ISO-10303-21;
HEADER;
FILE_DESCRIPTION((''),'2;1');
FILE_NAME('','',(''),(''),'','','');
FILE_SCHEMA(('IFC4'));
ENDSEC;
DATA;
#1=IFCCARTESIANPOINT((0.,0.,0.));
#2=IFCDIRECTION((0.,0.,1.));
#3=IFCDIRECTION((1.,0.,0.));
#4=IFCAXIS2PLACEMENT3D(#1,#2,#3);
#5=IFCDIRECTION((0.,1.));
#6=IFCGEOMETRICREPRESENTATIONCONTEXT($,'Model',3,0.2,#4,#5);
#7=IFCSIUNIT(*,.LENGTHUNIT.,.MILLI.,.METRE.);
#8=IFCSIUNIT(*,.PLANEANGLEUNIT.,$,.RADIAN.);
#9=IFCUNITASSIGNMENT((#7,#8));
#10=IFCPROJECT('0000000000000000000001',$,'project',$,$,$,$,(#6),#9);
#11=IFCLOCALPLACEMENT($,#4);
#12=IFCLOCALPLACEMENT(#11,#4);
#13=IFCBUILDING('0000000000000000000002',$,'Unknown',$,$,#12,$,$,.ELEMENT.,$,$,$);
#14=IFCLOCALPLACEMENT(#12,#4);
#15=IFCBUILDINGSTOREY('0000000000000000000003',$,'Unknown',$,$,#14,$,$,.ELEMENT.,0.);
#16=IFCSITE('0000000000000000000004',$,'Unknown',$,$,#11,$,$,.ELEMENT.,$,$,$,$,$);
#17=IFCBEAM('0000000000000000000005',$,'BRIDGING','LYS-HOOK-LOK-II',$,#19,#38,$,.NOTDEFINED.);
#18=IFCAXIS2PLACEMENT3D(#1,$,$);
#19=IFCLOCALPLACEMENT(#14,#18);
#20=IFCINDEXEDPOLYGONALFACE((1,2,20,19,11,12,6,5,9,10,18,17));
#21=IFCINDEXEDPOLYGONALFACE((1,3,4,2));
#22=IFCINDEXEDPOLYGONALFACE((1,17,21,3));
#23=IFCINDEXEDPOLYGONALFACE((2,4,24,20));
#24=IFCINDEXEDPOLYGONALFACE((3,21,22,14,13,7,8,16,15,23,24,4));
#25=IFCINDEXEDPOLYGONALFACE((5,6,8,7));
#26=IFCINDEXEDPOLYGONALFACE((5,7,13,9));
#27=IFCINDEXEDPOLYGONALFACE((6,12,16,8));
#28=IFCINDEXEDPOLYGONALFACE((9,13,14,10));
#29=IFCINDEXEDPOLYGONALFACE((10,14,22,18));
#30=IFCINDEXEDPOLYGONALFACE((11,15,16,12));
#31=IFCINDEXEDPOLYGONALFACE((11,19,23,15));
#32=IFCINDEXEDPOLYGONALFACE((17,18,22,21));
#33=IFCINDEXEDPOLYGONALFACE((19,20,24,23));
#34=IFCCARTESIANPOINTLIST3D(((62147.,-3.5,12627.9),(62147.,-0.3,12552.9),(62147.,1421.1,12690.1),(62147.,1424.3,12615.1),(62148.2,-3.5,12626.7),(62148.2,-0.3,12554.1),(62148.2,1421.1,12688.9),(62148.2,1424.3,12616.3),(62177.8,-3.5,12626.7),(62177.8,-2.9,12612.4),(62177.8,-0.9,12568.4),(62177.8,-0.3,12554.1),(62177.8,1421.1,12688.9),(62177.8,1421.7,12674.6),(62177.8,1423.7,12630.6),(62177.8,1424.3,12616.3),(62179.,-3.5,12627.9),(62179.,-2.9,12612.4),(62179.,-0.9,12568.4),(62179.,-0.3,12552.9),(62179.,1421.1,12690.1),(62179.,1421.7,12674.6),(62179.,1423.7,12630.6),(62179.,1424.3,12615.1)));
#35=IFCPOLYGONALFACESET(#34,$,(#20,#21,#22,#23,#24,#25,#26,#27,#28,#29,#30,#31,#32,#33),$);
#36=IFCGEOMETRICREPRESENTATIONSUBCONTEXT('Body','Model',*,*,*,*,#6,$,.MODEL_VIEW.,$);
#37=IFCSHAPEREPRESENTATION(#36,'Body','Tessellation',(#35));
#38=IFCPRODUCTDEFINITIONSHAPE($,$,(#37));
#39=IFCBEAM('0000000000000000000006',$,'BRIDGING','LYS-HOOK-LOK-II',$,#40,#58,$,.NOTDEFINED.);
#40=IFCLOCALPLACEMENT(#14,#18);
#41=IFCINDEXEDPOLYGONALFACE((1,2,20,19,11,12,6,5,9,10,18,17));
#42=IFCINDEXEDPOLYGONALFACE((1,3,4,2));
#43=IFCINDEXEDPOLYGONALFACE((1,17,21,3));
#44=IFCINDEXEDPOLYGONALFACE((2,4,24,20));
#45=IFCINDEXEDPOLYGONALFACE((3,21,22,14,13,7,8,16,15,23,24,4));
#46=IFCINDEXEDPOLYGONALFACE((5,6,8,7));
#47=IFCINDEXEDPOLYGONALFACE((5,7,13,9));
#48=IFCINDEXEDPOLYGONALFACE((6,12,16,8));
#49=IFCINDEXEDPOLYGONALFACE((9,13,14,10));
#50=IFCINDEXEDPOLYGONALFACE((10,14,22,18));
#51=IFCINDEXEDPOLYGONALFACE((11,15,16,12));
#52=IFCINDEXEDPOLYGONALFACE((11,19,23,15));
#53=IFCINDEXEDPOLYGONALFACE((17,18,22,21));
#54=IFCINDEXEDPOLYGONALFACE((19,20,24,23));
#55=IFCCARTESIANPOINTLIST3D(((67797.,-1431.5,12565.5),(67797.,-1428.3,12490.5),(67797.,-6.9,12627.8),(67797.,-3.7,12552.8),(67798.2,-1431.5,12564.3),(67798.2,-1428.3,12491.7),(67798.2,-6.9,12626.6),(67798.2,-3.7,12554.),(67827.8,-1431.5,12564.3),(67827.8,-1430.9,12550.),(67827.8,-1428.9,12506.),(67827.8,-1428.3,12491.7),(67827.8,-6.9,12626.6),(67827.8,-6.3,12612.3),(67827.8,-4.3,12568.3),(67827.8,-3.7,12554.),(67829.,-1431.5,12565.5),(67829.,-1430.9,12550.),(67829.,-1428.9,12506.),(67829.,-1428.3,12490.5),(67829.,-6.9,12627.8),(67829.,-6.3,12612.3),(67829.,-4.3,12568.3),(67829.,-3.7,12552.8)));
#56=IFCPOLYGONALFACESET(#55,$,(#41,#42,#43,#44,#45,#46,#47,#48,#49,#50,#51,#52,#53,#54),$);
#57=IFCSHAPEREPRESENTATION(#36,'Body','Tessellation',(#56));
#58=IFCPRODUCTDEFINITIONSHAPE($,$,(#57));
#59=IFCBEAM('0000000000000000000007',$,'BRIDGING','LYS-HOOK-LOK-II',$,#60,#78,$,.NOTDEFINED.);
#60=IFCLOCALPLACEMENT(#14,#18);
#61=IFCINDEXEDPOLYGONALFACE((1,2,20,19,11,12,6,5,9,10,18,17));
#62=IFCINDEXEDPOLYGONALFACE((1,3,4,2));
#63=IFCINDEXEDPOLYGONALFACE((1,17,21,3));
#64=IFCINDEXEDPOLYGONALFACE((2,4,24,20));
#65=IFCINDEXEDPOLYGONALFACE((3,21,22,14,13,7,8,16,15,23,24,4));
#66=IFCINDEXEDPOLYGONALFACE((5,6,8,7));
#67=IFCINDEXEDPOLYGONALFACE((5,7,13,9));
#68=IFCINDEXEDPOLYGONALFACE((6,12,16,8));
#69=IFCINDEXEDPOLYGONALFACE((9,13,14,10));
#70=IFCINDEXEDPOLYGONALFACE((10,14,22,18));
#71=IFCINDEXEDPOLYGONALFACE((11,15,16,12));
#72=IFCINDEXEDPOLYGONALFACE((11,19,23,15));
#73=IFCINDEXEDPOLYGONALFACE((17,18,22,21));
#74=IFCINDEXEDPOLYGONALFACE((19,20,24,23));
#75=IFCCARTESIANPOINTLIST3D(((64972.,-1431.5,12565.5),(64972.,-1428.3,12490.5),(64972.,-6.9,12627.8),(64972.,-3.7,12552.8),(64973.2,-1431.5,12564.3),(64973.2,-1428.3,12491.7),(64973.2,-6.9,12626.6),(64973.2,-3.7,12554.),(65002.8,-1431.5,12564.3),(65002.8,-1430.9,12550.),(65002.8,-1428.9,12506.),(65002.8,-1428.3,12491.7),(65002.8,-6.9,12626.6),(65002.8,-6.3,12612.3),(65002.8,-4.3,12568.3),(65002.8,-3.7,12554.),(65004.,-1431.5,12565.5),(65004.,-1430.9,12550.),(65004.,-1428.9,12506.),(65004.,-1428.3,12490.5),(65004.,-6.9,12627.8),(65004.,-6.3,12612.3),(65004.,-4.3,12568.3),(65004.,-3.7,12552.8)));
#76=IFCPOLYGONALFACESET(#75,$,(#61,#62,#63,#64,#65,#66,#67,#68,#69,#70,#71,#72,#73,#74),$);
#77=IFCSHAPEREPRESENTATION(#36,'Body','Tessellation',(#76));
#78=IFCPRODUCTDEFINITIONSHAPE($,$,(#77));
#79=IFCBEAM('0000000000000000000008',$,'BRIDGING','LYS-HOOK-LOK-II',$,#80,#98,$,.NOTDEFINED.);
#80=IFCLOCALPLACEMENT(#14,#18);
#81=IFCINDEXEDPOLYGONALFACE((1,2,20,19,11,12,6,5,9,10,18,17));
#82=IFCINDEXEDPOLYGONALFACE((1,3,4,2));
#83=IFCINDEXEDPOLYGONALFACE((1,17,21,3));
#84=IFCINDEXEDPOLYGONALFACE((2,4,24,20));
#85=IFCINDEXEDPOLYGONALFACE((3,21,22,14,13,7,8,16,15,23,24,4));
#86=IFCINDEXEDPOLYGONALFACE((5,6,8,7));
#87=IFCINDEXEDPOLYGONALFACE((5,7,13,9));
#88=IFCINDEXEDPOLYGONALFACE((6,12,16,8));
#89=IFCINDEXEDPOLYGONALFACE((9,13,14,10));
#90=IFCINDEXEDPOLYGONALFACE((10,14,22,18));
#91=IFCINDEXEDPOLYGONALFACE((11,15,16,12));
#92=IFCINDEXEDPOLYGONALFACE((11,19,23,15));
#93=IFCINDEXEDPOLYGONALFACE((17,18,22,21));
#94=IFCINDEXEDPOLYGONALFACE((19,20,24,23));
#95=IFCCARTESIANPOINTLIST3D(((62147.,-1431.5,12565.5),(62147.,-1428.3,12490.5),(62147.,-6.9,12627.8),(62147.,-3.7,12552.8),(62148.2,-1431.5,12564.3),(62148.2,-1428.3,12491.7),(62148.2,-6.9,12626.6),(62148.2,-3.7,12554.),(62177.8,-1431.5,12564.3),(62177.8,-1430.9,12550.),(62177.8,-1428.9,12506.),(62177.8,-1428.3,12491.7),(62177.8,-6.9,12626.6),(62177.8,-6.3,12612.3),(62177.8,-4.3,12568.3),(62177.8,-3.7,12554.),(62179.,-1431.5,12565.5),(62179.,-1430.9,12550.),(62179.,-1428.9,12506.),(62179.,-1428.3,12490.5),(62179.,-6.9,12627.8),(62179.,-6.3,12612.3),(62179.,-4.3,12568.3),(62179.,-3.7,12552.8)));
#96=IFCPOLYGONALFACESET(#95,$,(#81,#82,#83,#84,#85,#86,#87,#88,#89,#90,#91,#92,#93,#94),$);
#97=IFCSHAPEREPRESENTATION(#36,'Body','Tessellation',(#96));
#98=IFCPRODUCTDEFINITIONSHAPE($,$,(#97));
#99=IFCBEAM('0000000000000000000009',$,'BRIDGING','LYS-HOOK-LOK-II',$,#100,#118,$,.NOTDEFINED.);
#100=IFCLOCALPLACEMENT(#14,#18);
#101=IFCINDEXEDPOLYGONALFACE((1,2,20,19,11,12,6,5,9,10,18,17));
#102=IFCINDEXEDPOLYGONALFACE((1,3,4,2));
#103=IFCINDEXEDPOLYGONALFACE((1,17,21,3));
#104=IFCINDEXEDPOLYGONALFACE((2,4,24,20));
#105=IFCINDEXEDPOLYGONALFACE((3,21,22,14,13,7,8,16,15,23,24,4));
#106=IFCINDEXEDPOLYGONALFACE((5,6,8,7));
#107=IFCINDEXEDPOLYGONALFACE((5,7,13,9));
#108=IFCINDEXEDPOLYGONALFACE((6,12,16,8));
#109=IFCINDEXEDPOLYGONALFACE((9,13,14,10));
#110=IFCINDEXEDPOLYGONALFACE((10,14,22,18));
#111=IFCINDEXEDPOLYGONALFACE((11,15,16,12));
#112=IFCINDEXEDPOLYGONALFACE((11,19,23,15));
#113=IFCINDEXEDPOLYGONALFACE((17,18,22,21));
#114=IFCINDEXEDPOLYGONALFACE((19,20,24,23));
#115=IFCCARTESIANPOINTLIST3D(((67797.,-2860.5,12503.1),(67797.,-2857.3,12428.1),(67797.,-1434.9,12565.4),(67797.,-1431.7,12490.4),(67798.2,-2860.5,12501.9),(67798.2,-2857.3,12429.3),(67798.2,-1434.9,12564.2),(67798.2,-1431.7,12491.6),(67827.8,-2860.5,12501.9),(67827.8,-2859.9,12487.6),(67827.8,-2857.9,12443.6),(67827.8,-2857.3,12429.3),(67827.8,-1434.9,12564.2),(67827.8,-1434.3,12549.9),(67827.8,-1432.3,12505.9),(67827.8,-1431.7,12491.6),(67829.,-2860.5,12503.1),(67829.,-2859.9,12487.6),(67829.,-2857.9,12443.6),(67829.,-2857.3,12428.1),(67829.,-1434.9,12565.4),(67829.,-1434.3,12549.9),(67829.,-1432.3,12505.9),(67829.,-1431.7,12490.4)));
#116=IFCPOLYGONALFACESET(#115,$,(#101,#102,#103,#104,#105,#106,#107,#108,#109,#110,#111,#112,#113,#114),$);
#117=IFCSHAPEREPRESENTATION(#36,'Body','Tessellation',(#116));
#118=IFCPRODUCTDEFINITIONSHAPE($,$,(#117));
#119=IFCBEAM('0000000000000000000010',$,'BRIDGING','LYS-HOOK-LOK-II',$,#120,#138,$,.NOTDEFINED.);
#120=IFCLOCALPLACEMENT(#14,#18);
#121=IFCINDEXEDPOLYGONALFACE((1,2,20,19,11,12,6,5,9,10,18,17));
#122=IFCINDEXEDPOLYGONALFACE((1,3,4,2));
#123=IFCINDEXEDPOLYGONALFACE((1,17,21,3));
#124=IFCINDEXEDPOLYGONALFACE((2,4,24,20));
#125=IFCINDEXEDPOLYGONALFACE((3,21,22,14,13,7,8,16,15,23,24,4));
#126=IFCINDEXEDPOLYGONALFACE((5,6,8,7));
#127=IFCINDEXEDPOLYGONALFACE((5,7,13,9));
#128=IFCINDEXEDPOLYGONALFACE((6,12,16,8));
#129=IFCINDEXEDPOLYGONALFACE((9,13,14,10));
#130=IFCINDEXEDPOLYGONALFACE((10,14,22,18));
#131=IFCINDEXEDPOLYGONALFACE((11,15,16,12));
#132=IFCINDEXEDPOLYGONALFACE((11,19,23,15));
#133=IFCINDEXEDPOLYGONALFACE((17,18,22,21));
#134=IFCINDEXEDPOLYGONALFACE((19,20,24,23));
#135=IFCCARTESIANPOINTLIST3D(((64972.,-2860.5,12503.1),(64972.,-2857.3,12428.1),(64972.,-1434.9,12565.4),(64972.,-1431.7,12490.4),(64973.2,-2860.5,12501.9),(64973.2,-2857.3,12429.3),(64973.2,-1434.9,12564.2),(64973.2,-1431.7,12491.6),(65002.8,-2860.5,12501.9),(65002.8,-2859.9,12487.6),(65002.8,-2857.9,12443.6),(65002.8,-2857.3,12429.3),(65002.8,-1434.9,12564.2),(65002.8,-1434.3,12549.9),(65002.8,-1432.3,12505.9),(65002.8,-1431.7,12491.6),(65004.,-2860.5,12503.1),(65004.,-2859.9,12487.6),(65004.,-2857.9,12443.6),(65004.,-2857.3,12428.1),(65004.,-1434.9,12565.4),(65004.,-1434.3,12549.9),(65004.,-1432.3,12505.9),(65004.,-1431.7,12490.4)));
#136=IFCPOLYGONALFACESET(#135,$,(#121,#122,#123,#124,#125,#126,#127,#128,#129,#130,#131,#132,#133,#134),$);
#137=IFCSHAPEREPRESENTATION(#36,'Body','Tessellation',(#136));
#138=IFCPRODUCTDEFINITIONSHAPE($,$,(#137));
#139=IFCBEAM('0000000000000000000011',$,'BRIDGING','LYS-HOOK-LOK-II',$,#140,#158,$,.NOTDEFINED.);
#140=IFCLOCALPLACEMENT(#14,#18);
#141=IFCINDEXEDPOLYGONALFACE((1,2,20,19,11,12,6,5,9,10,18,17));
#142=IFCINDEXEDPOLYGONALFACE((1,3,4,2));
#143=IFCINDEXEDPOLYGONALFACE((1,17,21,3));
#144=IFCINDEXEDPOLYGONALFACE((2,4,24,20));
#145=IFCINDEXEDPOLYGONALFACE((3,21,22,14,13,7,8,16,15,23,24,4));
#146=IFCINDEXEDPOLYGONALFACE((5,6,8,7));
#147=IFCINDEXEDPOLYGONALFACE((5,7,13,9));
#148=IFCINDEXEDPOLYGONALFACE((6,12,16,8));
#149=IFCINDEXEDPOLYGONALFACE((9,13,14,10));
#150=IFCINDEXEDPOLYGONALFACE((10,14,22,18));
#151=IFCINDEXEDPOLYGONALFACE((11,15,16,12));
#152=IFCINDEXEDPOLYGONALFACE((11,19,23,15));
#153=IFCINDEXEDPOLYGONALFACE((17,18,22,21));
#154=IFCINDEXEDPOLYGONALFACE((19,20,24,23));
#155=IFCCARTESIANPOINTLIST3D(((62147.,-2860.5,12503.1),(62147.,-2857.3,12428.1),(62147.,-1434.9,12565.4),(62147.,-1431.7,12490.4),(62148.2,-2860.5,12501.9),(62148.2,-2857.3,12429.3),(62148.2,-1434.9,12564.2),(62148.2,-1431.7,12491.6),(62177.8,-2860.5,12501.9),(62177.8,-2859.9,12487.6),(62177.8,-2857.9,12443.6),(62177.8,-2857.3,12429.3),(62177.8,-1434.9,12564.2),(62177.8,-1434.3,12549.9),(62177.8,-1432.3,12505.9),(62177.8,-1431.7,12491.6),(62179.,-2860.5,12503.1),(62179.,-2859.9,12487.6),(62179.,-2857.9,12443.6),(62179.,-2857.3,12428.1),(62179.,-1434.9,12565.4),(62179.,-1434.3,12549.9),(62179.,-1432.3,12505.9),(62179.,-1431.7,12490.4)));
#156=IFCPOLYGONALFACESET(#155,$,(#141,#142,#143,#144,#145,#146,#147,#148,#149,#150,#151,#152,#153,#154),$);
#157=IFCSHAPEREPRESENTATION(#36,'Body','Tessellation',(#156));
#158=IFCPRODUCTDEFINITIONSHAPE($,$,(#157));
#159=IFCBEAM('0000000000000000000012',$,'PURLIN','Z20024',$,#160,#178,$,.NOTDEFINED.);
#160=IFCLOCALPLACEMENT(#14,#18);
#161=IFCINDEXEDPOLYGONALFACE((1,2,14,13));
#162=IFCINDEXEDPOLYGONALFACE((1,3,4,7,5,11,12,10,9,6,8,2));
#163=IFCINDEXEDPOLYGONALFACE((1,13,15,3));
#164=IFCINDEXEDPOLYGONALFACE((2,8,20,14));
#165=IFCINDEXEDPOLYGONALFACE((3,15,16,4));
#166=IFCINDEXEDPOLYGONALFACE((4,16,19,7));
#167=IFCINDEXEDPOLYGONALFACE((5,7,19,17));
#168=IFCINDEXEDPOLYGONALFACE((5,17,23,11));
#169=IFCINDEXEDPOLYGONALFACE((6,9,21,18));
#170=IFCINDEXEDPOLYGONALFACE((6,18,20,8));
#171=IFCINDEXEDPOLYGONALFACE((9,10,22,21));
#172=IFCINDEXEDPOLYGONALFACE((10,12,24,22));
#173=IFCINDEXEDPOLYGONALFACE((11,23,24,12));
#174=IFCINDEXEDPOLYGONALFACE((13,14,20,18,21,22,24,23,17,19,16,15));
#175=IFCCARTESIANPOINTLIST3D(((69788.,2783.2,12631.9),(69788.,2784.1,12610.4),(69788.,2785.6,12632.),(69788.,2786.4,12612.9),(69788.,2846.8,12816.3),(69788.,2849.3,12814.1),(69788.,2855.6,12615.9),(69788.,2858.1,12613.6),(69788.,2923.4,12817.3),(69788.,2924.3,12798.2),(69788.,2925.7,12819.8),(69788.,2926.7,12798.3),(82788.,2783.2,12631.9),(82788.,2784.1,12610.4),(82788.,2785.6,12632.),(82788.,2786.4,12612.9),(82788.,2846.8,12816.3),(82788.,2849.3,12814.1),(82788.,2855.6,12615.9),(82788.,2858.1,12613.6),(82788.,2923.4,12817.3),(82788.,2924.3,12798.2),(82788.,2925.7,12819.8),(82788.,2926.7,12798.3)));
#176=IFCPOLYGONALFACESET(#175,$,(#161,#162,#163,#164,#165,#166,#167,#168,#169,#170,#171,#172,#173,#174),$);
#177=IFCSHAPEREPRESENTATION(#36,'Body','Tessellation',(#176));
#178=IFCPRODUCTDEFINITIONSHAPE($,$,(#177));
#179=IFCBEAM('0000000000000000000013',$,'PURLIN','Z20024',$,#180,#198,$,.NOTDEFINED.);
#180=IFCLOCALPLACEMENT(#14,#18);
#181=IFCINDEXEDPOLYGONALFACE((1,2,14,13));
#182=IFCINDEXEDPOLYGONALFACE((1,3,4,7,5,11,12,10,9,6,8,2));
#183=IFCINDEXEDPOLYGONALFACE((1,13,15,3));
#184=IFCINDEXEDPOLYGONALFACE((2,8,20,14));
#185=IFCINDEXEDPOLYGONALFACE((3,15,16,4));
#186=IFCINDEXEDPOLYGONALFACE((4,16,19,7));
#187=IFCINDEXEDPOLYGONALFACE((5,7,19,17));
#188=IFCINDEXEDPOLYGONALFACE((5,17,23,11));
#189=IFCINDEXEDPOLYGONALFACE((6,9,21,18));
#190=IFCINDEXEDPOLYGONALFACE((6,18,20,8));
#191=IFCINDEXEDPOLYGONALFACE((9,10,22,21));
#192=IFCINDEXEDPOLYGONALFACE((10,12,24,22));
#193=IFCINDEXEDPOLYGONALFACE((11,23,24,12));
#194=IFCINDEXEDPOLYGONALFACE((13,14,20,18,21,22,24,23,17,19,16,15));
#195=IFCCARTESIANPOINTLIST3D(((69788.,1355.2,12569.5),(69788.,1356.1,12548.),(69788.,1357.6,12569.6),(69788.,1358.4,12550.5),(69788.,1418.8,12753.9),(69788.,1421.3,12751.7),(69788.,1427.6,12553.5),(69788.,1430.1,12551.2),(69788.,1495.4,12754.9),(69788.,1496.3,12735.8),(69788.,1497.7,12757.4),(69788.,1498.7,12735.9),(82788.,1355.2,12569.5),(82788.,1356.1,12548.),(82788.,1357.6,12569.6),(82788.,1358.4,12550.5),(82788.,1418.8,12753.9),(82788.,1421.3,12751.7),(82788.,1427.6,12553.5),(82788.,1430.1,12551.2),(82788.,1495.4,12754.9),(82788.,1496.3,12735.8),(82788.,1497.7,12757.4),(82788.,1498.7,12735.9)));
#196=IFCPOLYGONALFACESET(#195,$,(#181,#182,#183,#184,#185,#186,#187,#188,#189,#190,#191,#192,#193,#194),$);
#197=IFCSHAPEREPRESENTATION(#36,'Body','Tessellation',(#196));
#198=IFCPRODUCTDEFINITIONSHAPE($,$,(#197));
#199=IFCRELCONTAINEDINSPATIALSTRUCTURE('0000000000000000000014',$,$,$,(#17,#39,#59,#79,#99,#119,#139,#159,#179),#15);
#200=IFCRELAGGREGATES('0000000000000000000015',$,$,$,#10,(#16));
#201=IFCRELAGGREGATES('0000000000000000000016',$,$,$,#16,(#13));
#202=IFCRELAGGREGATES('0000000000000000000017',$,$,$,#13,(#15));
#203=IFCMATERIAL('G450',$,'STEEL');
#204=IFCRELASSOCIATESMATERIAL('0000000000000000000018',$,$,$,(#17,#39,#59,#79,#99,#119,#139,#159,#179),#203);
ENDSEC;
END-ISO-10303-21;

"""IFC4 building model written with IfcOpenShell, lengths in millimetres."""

from ifc_helpers import new_model, si_unit, direction, frame, origin_with_axes, place, context, subcontext, project, spatial, line, indexed_curve, outline, extrude, material, element, save


model = new_model("IFC4")

# Units and contexts
model_context = context("Model", 3, precision=0.2, world=origin_with_axes(), true_north=direction((0.0, 1.0)))
body_context = subcontext(model_context, "Body", "Model", "MODEL_VIEW")
ifc_project = project(units=[si_unit("LENGTHUNIT", "METRE", prefix="MILLI"), si_unit("PLANEANGLEUNIT", "RADIAN")], contexts=[model_context])

# Site, building, storey
site_placement = place(None, origin_with_axes())
site = spatial("IfcSite", under=ifc_project, at=site_placement, Name="Unknown", CompositionType="ELEMENT")
building_placement = place(site_placement, origin_with_axes())
building = spatial("IfcBuilding", under=site, at=building_placement, Name="Unknown", CompositionType="ELEMENT")
storey_placement = place(building_placement, origin_with_axes())
storey = spatial("IfcBuildingStorey", under=building, at=storey_placement, Name="Unknown", CompositionType="ELEMENT", Elevation=0.0)

# Beams
ifc_material_1 = material(Name="G450", Category="STEEL")
for number, where, z_axis, x_axis, name in (
    (1, (62163.0, -1.9, 12590.4), (1.0, 0.0, 0.0), (0.0, 0.999048, 0.04362), "BRIDGING"),
):
    element("IfcBeam", number, at=place(storey_placement, frame(where, z_axis=z_axis, x_axis=x_axis)), inside=storey, material=ifc_material_1, Name=name, Description="LYS-HOOK-LOK-II", PredefinedType="NOTDEFINED", context=body_context, shape_type="SolidModel", body=[
        extrude(outline(indexed_curve([(16.0, -37.5), (16.0, -22.0), (14.8, -22.0), (14.8, -36.3), (-14.8, -36.3), (-14.8, 36.3), (14.8, 36.3), (14.8, 22.0), (16.0, 22.0), (16.0, 37.5), (-16.0, 37.5), (-16.0, -37.5)], segments=[line(1, 2, 3, 4, 5, 6, 7, 8, 9, 10, 11, 12, 1)])), frame((0.0, 0.0, 0.0), z_axis=(-1.0, 0.0, 0.0), x_axis=(0.0, 0.0, 1.0)), (0.0, 0.0, -1.0), 1426.0),
    ])
for number, where, z_axis, x_axis, name in (
    (2, (67813.0, -1429.9, 12528.0), (1.0, 0.0, 0.0), (0.0, 0.999045, 0.04369), "BRIDGING"),
    (3, (64988.0, -1429.9, 12528.0), (1.0, 0.0, 0.0), (0.0, 0.999045, 0.04369), "BRIDGING"),
    (4, (62163.0, -1429.9, 12528.0), (1.0, 0.0, 0.0), (0.0, 0.999045, 0.04369), "BRIDGING"),
):
    element("IfcBeam", number, at=place(storey_placement, frame(where, z_axis=z_axis, x_axis=x_axis)), inside=storey, material=ifc_material_1, Name=name, Description="LYS-HOOK-LOK-II", PredefinedType="NOTDEFINED", context=body_context, shape_type="SolidModel", body=[
        extrude(outline(indexed_curve([(16.0, -37.5), (16.0, -22.0), (14.8, -22.0), (14.8, -36.3), (-14.8, -36.3), (-14.8, 36.3), (14.8, 36.3), (14.8, 22.0), (16.0, 22.0), (16.0, 37.5), (-16.0, 37.5), (-16.0, -37.5)], segments=[line(1, 2, 3, 4, 5, 6, 7, 8, 9, 10, 11, 12, 1)])), frame((0.0, 0.0, 0.0), z_axis=(-1.0, 0.0, 0.0), x_axis=(0.0, 0.0, 1.0)), (0.0, 0.0, -1.0), 1426.0),
    ])
for number, where, z_axis, x_axis, name in (
    (5, (67813.0, -2858.9, 12465.6), (1.0, 0.0, 0.0), (0.0, 0.999046, 0.043659), "BRIDGING"),
    (6, (64988.0, -2858.9, 12465.6), (1.0, 0.0, 0.0), (0.0, 0.999046, 0.043659), "BRIDGING"),
    (7, (62163.0, -2858.9, 12465.6), (1.0, 0.0, 0.0), (0.0, 0.999046, 0.043659), "BRIDGING"),
):
    element("IfcBeam", number, at=place(storey_placement, frame(where, z_axis=z_axis, x_axis=x_axis)), inside=storey, material=ifc_material_1, Name=name, Description="LYS-HOOK-LOK-II", PredefinedType="NOTDEFINED", context=body_context, shape_type="SolidModel", body=[
        extrude(outline(indexed_curve([(16.0, -37.5), (16.0, -22.0), (14.8, -22.0), (14.8, -36.3), (-14.8, -36.3), (-14.8, 36.3), (14.8, 36.3), (14.8, 22.0), (16.0, 22.0), (16.0, 37.5), (-16.0, 37.5), (-16.0, -37.5)], segments=[line(1, 2, 3, 4, 5, 6, 7, 8, 9, 10, 11, 12, 1)])), frame((0.0, 0.0, 0.0), z_axis=(-1.0, 0.0, 0.0), x_axis=(0.0, 0.0, 1.0)), (0.0, 0.0, -1.0), 1427.0),
    ])
for number, where, z_axis, x_axis, name in (
    (8, (69788.0, 2852.4, 12715.0), (0.0, -0.999048, -0.043619), (1.0, 0.0, 0.0), "PURLIN"),
    (9, (69788.0, 1424.4, 12652.6), (0.0, -0.999048, -0.043619), (1.0, 0.0, 0.0), "PURLIN"),
):
    element("IfcBeam", number, at=place(storey_placement, frame(where, z_axis=z_axis, x_axis=x_axis)), inside=storey, material=ifc_material_1, Name=name, Description="Z20024", PredefinedType="NOTDEFINED", context=body_context, shape_type="SolidModel", body=[
        extrude(outline(indexed_curve([(72.8, -101.5), (72.8, -80.0), (70.4, -80.0), (70.4, -99.1), (1.2, -99.1), (1.2, 101.5), (-77.8, 101.5), (-77.8, 80.0), (-75.4, 80.0), (-75.4, 99.1), (-1.2, 99.1), (-1.2, -101.5)], segments=[line(1, 2, 3, 4, 5, 6, 7, 8, 9, 10, 11, 12, 1)])), frame((0.0, 0.0, 0.0), z_axis=(-1.0, 0.0, 0.0), x_axis=(0.0, 0.0, 1.0)), (0.0, 0.0, -1.0), 13000.0),
    ])

save(model, "model.ifc")
